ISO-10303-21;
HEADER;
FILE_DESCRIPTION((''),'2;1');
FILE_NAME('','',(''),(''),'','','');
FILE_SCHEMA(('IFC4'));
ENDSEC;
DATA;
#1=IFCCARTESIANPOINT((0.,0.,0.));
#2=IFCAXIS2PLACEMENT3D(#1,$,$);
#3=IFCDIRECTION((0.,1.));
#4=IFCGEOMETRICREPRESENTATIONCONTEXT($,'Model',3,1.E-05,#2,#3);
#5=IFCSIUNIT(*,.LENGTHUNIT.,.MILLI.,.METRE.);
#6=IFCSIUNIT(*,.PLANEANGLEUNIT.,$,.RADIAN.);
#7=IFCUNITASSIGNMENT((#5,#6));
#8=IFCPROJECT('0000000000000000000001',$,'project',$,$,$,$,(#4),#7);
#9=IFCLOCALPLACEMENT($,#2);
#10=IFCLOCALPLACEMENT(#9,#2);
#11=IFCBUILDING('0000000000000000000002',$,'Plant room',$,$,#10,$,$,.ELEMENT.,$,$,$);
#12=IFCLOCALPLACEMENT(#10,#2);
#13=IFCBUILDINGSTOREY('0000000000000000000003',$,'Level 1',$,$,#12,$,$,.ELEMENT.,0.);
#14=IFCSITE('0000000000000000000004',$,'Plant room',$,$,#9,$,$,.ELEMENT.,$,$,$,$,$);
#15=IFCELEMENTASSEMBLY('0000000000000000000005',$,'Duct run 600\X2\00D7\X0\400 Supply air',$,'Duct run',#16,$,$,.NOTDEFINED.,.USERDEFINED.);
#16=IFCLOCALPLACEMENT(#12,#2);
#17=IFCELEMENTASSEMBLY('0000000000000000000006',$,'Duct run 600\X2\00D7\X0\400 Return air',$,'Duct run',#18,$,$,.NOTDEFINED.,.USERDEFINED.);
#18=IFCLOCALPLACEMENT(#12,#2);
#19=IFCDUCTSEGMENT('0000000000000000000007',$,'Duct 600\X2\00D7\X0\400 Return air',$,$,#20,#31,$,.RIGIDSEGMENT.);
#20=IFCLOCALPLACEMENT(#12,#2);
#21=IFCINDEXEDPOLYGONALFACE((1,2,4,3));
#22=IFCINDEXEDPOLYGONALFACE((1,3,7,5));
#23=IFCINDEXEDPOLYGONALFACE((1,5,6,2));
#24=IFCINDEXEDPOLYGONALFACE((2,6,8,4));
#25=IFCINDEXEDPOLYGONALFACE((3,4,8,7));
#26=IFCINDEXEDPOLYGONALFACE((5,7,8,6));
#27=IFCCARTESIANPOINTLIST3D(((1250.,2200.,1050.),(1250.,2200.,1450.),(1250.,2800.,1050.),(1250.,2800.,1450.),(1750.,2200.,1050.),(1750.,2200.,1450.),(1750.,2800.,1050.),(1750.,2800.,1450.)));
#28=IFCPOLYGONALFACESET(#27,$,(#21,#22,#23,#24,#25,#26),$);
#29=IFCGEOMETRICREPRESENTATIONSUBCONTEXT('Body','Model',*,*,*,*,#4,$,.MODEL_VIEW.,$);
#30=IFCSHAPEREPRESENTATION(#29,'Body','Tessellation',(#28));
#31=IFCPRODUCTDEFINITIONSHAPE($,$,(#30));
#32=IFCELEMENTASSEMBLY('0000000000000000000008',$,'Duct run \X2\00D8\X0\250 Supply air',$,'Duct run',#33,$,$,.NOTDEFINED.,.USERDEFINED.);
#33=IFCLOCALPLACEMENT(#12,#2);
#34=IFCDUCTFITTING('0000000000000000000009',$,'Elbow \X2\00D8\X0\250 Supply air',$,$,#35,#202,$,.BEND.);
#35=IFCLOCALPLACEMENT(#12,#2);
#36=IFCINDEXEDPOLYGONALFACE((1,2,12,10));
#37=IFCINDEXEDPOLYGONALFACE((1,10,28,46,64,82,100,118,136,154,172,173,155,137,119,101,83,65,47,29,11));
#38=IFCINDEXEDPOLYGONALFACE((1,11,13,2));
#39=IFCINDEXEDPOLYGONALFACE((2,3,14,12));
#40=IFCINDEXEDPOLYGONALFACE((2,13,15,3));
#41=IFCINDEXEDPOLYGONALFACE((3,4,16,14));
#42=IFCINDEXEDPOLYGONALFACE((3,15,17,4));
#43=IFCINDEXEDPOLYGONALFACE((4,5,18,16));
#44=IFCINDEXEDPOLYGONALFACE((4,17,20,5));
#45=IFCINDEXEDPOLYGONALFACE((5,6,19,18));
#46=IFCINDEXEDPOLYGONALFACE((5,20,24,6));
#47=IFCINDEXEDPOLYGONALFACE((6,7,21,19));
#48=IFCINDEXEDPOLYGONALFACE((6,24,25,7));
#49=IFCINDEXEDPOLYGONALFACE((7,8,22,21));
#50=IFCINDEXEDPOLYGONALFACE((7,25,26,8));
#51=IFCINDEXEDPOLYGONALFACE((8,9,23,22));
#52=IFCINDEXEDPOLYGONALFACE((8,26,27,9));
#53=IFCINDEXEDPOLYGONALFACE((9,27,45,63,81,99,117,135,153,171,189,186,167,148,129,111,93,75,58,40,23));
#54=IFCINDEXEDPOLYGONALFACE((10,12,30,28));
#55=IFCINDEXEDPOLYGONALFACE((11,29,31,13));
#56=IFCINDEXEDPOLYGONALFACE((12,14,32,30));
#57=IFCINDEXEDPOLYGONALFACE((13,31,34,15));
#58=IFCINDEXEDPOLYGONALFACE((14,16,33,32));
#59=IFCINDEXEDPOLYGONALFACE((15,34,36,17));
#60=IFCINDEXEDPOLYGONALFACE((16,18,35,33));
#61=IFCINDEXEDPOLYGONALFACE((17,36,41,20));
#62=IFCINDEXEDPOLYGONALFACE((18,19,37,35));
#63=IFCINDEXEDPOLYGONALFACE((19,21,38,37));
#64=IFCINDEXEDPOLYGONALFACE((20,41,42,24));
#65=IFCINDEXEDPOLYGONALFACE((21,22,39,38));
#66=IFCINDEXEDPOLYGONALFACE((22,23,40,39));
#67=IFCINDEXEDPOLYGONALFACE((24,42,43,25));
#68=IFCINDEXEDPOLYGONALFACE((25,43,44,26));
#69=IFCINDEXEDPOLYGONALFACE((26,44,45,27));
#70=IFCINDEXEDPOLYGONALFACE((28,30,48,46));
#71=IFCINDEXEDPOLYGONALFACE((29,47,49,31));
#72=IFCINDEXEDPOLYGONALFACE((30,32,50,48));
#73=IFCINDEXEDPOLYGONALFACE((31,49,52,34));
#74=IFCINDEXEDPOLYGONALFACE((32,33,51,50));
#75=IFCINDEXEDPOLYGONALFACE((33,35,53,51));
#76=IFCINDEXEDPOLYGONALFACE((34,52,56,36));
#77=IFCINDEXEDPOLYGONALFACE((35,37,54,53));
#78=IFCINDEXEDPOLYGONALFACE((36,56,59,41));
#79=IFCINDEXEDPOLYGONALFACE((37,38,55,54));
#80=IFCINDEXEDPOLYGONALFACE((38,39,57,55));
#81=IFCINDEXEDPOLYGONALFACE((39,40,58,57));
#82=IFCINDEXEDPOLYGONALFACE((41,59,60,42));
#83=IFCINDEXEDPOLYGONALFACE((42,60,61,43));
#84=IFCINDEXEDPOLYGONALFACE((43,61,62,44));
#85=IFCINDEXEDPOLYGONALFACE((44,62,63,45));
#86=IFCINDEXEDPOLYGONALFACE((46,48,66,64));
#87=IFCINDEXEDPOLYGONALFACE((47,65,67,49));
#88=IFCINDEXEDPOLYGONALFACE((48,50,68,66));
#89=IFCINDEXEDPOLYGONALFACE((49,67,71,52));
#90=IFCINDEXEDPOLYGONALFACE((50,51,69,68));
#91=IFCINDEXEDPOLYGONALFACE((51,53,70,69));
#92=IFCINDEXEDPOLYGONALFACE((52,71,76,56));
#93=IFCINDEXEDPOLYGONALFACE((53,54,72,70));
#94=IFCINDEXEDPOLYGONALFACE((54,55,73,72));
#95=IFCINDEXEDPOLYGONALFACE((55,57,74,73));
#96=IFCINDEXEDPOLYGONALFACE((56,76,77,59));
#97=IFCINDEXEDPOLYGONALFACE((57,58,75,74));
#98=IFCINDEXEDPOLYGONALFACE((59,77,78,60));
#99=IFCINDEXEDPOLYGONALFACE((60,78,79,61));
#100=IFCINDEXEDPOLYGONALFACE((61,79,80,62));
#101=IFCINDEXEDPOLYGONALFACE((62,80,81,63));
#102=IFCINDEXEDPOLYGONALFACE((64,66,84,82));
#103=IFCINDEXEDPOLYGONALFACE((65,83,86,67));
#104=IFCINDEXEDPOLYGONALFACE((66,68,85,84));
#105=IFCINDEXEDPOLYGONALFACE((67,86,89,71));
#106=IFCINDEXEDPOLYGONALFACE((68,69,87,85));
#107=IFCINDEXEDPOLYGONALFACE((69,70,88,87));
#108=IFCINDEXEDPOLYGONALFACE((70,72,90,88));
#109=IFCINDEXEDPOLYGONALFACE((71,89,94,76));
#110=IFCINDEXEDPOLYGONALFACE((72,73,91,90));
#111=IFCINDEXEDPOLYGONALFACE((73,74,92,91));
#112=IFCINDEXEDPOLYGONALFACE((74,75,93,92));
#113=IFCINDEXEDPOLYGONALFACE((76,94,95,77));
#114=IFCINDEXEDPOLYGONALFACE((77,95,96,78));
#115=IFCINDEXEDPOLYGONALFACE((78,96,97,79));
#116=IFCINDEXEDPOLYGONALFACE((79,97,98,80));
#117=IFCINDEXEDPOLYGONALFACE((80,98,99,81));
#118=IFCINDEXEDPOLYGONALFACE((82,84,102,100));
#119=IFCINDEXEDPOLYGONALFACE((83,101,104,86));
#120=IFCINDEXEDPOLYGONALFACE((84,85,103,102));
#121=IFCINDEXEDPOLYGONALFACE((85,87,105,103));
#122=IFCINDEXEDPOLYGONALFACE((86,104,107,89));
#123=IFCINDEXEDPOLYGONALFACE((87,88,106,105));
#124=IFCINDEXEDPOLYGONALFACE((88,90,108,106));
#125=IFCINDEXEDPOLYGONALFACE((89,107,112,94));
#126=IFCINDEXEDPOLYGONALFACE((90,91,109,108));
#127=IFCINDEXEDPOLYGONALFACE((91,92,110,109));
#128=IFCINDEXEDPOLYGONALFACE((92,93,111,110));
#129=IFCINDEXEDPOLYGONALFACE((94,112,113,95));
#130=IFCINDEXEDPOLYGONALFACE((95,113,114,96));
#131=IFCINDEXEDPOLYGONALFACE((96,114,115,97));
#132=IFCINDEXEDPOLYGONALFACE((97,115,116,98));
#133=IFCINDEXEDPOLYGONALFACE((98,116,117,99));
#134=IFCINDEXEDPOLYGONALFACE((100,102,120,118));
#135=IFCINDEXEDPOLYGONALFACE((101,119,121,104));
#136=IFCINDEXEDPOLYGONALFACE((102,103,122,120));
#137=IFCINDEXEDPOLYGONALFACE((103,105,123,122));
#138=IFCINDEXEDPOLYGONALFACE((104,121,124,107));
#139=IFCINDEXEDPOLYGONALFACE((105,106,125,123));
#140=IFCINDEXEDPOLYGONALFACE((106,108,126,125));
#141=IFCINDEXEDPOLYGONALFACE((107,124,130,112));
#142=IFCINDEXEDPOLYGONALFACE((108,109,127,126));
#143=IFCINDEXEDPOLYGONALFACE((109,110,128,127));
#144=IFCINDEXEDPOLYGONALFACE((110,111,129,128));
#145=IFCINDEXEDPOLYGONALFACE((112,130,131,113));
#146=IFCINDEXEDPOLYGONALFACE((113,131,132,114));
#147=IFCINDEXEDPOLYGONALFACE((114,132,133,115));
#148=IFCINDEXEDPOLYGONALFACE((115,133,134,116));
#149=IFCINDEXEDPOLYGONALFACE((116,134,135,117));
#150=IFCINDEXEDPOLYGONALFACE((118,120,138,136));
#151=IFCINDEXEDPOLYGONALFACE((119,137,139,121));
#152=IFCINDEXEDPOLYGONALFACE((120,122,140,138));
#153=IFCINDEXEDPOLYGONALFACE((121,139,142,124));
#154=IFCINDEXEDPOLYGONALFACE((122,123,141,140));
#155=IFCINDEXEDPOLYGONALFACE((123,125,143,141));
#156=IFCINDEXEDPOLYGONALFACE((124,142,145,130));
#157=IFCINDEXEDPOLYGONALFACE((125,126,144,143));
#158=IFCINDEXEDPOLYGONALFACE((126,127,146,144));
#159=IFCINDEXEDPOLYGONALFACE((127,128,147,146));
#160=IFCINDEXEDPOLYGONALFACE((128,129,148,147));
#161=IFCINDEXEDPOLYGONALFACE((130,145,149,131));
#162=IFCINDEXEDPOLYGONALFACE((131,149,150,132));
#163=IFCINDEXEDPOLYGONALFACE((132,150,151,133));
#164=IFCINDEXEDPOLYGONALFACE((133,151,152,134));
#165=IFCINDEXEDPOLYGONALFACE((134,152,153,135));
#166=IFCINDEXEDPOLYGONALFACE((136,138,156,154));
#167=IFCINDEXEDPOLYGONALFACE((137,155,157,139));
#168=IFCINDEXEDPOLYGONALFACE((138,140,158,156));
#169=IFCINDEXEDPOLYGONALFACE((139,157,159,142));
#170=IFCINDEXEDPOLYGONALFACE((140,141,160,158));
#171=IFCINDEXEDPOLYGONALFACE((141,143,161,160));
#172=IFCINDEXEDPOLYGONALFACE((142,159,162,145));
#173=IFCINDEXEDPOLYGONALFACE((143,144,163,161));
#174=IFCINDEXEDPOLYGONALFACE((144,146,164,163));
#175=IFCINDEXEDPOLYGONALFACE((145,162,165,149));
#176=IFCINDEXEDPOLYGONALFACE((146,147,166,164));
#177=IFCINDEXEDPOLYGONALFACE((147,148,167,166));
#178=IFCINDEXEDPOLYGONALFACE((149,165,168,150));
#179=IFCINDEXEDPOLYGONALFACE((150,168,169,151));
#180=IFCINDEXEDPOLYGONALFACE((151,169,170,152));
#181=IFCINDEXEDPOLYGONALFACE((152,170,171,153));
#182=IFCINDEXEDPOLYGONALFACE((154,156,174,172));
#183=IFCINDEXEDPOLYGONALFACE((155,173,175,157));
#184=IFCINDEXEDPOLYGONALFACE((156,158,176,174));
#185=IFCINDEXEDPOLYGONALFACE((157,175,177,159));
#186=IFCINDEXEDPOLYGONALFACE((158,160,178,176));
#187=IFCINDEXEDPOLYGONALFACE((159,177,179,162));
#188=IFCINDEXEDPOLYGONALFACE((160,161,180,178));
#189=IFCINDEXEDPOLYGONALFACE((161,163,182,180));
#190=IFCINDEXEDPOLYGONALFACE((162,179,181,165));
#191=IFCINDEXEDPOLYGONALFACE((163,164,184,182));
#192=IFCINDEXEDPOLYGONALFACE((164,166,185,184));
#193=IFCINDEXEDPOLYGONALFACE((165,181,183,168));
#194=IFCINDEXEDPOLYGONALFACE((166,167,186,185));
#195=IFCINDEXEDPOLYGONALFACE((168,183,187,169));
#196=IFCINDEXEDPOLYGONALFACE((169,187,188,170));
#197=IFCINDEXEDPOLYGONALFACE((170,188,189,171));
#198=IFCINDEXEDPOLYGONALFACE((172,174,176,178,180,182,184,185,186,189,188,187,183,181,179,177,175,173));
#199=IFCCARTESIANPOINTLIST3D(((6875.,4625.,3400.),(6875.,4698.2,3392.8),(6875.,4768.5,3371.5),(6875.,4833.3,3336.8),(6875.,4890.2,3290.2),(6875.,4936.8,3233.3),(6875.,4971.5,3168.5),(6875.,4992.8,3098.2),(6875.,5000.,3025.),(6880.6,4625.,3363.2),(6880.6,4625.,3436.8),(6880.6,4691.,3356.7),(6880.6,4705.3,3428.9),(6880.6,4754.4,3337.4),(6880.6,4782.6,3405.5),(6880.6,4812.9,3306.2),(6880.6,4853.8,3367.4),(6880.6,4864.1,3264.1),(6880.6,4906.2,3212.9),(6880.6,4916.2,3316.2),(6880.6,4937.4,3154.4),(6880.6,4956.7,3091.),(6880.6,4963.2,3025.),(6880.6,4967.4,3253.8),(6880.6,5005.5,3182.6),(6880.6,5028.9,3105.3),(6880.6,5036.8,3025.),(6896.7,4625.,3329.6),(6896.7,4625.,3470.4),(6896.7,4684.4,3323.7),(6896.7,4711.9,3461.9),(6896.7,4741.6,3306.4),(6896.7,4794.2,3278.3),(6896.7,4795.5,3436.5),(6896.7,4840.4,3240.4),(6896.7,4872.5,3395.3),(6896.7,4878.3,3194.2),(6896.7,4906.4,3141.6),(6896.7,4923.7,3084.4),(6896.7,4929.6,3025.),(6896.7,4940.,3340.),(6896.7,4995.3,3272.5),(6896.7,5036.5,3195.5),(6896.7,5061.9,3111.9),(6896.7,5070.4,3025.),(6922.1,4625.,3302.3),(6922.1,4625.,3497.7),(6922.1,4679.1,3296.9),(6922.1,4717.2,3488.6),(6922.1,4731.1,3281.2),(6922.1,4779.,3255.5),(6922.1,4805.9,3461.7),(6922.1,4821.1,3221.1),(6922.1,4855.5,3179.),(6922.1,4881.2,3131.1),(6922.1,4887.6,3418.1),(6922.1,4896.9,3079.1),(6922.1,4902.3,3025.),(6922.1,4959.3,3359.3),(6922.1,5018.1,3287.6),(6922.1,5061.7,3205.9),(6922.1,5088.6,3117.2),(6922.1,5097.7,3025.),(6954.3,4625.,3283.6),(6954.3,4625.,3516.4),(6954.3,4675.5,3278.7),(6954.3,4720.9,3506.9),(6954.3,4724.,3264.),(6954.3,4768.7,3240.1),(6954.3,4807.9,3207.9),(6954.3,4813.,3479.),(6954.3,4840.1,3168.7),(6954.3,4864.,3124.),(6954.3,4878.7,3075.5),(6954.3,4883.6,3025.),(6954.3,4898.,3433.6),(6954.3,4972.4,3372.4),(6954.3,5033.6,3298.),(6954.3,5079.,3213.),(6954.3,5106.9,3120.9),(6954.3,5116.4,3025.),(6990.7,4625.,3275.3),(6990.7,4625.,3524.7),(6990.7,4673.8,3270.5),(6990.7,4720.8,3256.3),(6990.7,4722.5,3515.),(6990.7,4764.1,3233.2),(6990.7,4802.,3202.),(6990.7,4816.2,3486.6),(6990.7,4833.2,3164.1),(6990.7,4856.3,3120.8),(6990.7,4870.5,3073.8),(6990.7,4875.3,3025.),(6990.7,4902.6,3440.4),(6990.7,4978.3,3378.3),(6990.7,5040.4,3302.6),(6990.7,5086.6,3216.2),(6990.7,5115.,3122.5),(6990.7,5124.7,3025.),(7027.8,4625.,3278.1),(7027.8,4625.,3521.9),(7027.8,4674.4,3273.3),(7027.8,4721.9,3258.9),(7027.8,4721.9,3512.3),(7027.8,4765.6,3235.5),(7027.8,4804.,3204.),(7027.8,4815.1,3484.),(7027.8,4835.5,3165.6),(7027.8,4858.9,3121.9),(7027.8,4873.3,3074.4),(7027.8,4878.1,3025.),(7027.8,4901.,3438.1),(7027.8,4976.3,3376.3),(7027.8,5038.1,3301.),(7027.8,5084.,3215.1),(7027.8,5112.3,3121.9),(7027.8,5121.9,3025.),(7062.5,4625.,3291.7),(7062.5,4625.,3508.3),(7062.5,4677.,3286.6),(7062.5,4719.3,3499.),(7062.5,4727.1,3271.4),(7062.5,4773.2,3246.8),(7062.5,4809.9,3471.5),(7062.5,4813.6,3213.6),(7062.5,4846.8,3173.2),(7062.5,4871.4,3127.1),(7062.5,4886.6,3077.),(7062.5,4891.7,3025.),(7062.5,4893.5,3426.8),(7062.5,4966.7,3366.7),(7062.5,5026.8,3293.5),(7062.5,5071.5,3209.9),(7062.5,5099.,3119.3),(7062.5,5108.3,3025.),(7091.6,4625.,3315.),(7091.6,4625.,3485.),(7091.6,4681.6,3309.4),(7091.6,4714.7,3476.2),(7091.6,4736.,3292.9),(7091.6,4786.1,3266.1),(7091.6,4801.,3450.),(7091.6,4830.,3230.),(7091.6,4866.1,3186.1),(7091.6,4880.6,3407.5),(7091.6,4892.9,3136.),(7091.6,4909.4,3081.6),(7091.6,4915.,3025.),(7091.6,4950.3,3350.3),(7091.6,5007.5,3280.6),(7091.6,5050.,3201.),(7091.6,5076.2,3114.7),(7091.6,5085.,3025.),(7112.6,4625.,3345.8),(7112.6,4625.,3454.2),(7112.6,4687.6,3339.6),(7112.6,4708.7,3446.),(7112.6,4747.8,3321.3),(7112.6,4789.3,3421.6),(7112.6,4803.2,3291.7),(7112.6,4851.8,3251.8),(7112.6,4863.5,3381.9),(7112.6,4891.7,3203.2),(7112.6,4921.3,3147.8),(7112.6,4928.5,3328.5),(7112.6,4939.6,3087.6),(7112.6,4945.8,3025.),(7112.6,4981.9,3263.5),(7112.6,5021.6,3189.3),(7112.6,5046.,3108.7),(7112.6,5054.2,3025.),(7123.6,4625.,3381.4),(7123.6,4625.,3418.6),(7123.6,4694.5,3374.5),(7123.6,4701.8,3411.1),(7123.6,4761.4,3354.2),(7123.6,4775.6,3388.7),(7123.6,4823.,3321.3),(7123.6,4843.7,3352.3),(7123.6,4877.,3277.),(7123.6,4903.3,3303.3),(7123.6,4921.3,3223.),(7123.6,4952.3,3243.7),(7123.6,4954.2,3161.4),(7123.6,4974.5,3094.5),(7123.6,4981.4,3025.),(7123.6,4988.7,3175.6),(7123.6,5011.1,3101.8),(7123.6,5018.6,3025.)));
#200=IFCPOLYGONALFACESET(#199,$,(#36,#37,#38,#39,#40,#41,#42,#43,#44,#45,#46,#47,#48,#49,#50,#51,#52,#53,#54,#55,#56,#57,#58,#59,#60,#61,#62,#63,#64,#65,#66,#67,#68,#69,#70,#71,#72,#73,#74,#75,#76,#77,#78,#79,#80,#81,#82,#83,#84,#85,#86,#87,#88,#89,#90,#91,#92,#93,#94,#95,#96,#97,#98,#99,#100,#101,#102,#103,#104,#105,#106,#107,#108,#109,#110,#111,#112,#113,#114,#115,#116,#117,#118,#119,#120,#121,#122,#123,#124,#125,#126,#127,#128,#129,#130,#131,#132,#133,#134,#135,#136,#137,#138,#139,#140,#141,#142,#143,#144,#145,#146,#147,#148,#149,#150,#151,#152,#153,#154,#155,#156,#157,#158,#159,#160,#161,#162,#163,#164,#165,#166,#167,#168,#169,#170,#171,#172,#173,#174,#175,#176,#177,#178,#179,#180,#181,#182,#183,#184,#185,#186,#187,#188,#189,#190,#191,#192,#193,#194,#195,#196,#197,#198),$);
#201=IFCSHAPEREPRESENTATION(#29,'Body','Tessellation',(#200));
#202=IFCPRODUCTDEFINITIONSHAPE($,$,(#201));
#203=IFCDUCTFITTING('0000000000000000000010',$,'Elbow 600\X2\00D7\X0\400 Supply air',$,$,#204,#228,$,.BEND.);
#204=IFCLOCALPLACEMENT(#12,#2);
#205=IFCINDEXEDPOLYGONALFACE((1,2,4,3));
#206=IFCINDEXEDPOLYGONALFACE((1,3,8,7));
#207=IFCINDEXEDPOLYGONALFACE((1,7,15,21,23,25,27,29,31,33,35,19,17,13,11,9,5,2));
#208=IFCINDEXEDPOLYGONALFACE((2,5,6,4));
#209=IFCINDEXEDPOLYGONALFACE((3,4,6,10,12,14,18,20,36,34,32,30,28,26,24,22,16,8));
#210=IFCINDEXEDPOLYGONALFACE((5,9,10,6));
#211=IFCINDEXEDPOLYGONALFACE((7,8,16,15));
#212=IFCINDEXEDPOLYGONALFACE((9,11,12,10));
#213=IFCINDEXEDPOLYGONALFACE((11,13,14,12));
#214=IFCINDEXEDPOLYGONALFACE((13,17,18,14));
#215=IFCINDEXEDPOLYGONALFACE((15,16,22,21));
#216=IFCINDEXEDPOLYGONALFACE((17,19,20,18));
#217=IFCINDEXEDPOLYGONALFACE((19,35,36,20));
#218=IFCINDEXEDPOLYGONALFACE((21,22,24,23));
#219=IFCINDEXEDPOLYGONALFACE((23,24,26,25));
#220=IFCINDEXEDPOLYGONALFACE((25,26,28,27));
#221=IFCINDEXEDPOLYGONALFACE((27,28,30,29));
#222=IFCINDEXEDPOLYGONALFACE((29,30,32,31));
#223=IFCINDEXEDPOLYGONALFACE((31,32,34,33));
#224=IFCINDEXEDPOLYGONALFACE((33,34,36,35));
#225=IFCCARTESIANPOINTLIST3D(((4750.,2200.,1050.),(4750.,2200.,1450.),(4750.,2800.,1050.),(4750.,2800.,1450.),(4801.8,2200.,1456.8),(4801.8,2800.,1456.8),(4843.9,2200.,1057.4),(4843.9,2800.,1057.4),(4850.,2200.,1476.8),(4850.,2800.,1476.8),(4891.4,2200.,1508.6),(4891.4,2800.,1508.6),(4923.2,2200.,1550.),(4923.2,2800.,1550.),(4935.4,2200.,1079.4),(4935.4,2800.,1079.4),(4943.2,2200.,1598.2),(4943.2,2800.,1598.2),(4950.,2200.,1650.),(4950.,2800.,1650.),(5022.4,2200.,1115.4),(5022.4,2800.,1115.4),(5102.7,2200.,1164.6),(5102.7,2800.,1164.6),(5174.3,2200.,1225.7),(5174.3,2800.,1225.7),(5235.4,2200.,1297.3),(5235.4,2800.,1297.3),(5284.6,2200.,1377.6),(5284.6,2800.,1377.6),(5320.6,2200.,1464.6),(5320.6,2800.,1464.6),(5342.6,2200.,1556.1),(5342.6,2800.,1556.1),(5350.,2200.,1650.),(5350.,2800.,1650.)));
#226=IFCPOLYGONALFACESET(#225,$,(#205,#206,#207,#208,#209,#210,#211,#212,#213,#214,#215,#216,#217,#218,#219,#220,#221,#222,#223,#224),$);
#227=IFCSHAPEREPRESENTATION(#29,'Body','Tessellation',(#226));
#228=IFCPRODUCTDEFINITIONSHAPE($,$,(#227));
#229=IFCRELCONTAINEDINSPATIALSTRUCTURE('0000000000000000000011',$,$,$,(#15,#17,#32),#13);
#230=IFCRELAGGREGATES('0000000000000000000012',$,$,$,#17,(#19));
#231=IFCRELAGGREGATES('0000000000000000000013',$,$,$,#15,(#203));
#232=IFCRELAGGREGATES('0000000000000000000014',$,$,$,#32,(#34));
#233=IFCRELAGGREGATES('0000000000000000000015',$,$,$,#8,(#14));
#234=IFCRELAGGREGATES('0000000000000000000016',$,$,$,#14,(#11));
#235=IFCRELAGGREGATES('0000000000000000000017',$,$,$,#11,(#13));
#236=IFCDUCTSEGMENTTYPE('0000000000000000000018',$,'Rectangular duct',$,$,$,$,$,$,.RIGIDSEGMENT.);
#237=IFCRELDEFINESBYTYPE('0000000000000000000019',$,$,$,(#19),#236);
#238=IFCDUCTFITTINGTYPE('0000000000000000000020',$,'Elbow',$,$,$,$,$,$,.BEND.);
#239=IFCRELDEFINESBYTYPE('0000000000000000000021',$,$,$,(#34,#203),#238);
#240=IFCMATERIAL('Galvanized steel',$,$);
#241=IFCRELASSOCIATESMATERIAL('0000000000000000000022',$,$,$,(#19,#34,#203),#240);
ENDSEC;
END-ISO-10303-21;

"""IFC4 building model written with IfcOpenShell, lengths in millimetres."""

from ifc_helpers import new_model, entity, si_unit, direction, frame, origin, origin_with_axes, origin_2d, place, context, subcontext, project, spatial, rectangle, extrude, material, type_object, element, aggregate, save


model = new_model("IFC4")

# Units and contexts
model_context = context("Model", 3, precision=1e-05, world=origin(), true_north=direction((0.0, 1.0)))
body_context = subcontext(model_context, "Body", "Model", "MODEL_VIEW")
ifc_project = project(units=[si_unit("LENGTHUNIT", "METRE", prefix="MILLI"), si_unit("PLANEANGLEUNIT", "RADIAN")], contexts=[model_context])

# Site, building, storey
site_placement = place(None, origin())
site = spatial("IfcSite", under=ifc_project, at=site_placement, Name="Plant room", CompositionType="ELEMENT")
building_placement = place(site_placement, origin())
building = spatial("IfcBuilding", under=site, at=building_placement, Name="Plant room", CompositionType="ELEMENT")
storey_placement = place(building_placement, origin())
storey = spatial("IfcBuildingStorey", under=building, at=storey_placement, Name="Level 1", CompositionType="ELEMENT", Elevation=0.0)

# Element assemblies, duct segment
assembly_1_placement = place(storey_placement, origin_with_axes())
assembly_1 = element("IfcElementAssembly", 1, at=assembly_1_placement, inside=storey, Name="Duct run 600×400 Supply air", ObjectType="Duct run", AssemblyPlace="NOTDEFINED", PredefinedType="USERDEFINED")
ifc_material_1 = material(Name="Galvanized steel")
duct_segment_type_1 = type_object("IfcDuctSegmentType", Name="Rectangular duct", PredefinedType="RIGIDSEGMENT")
assembly_2_placement = place(storey_placement, origin_with_axes())
assembly_2 = element("IfcElementAssembly", 2, at=assembly_2_placement, inside=storey, Name="Duct run 600×400 Return air", ObjectType="Duct run", AssemblyPlace="NOTDEFINED", PredefinedType="USERDEFINED")
duct_segment_1_placement = place(storey_placement, origin_with_axes())
duct_segment_1 = element("IfcDuctSegment", 3, at=duct_segment_1_placement, type_object=duct_segment_type_1, material=ifc_material_1, Name="Duct 600×400 Return air", PredefinedType="RIGIDSEGMENT", context=body_context, shape_type="SweptSolid", body=[
    extrude(rectangle(XDim=600.0, YDim=400.0, at=origin_2d()), frame((1250.0, 2500.0, 1250.0), z_axis=(1.0, 0.0, 0.0), x_axis=(0.0, 1.0, 0.0)), (0.0, 0.0, 1.0), 500.0),
])

# Element assembly, duct fitting
assembly_3_placement = place(storey_placement, origin_with_axes())
assembly_3 = element("IfcElementAssembly", 4, at=assembly_3_placement, inside=storey, Name="Duct run Ø250 Supply air", ObjectType="Duct run", AssemblyPlace="NOTDEFINED", PredefinedType="USERDEFINED")
duct_fitting_type_1 = type_object("IfcDuctFittingType", Name="Elbow", PredefinedType="BEND")
duct_fitting_1_placement = place(storey_placement, origin_with_axes())
duct_fitting_1 = element("IfcDuctFitting", 5, at=duct_fitting_1_placement, type_object=duct_fitting_type_1, material=ifc_material_1, Name="Elbow Ø250 Supply air", PredefinedType="BEND", context=body_context, shape_type="SweptSolid", body=[
    entity("IfcRevolvedAreaSolid", entity("IfcCircleProfileDef", "AREA", None, entity("IfcAxis2Placement2D", entity("IfcCartesianPoint", [0.0, 0.0])), 125.0), entity("IfcAxis2Placement3D", entity("IfcCartesianPoint", [7000.0, 4625.0, 3400.0]), entity("IfcDirection", [0.0, 1.0, 0.0]), entity("IfcDirection", [-1.0, 0.0, 0.0])), entity("IfcAxis1Placement", entity("IfcCartesianPoint", [0.0, -375.0, 0.0]), entity("IfcDirection", [1.0, 0.0, 0.0])), 1.570796),
])

# Duct fitting
duct_fitting_2_placement = place(storey_placement, origin_with_axes())
duct_fitting_2 = element("IfcDuctFitting", 6, at=duct_fitting_2_placement, type_object=duct_fitting_type_1, material=ifc_material_1, Name="Elbow 600×400 Supply air", PredefinedType="BEND", context=body_context, shape_type="SweptSolid", body=[
    entity("IfcRevolvedAreaSolid", entity("IfcRectangleProfileDef", "AREA", None, entity("IfcAxis2Placement2D", entity("IfcCartesianPoint", [0.0, 0.0])), 600.0, 400.0), entity("IfcAxis2Placement3D", entity("IfcCartesianPoint", [4750.0, 2500.0, 1250.0]), entity("IfcDirection", [1.0, 0.0, 0.0]), entity("IfcDirection", [0.0, 1.0, 0.0])), entity("IfcAxis1Placement", entity("IfcCartesianPoint", [0.0, 400.0, 0.0]), entity("IfcDirection", [-1.0, 0.0, 0.0])), 1.570796),
])

aggregate(assembly_2, [duct_segment_1])
aggregate(assembly_1, [duct_fitting_2])

aggregate(assembly_3, [duct_fitting_1])

save(model, "model.ifc")
